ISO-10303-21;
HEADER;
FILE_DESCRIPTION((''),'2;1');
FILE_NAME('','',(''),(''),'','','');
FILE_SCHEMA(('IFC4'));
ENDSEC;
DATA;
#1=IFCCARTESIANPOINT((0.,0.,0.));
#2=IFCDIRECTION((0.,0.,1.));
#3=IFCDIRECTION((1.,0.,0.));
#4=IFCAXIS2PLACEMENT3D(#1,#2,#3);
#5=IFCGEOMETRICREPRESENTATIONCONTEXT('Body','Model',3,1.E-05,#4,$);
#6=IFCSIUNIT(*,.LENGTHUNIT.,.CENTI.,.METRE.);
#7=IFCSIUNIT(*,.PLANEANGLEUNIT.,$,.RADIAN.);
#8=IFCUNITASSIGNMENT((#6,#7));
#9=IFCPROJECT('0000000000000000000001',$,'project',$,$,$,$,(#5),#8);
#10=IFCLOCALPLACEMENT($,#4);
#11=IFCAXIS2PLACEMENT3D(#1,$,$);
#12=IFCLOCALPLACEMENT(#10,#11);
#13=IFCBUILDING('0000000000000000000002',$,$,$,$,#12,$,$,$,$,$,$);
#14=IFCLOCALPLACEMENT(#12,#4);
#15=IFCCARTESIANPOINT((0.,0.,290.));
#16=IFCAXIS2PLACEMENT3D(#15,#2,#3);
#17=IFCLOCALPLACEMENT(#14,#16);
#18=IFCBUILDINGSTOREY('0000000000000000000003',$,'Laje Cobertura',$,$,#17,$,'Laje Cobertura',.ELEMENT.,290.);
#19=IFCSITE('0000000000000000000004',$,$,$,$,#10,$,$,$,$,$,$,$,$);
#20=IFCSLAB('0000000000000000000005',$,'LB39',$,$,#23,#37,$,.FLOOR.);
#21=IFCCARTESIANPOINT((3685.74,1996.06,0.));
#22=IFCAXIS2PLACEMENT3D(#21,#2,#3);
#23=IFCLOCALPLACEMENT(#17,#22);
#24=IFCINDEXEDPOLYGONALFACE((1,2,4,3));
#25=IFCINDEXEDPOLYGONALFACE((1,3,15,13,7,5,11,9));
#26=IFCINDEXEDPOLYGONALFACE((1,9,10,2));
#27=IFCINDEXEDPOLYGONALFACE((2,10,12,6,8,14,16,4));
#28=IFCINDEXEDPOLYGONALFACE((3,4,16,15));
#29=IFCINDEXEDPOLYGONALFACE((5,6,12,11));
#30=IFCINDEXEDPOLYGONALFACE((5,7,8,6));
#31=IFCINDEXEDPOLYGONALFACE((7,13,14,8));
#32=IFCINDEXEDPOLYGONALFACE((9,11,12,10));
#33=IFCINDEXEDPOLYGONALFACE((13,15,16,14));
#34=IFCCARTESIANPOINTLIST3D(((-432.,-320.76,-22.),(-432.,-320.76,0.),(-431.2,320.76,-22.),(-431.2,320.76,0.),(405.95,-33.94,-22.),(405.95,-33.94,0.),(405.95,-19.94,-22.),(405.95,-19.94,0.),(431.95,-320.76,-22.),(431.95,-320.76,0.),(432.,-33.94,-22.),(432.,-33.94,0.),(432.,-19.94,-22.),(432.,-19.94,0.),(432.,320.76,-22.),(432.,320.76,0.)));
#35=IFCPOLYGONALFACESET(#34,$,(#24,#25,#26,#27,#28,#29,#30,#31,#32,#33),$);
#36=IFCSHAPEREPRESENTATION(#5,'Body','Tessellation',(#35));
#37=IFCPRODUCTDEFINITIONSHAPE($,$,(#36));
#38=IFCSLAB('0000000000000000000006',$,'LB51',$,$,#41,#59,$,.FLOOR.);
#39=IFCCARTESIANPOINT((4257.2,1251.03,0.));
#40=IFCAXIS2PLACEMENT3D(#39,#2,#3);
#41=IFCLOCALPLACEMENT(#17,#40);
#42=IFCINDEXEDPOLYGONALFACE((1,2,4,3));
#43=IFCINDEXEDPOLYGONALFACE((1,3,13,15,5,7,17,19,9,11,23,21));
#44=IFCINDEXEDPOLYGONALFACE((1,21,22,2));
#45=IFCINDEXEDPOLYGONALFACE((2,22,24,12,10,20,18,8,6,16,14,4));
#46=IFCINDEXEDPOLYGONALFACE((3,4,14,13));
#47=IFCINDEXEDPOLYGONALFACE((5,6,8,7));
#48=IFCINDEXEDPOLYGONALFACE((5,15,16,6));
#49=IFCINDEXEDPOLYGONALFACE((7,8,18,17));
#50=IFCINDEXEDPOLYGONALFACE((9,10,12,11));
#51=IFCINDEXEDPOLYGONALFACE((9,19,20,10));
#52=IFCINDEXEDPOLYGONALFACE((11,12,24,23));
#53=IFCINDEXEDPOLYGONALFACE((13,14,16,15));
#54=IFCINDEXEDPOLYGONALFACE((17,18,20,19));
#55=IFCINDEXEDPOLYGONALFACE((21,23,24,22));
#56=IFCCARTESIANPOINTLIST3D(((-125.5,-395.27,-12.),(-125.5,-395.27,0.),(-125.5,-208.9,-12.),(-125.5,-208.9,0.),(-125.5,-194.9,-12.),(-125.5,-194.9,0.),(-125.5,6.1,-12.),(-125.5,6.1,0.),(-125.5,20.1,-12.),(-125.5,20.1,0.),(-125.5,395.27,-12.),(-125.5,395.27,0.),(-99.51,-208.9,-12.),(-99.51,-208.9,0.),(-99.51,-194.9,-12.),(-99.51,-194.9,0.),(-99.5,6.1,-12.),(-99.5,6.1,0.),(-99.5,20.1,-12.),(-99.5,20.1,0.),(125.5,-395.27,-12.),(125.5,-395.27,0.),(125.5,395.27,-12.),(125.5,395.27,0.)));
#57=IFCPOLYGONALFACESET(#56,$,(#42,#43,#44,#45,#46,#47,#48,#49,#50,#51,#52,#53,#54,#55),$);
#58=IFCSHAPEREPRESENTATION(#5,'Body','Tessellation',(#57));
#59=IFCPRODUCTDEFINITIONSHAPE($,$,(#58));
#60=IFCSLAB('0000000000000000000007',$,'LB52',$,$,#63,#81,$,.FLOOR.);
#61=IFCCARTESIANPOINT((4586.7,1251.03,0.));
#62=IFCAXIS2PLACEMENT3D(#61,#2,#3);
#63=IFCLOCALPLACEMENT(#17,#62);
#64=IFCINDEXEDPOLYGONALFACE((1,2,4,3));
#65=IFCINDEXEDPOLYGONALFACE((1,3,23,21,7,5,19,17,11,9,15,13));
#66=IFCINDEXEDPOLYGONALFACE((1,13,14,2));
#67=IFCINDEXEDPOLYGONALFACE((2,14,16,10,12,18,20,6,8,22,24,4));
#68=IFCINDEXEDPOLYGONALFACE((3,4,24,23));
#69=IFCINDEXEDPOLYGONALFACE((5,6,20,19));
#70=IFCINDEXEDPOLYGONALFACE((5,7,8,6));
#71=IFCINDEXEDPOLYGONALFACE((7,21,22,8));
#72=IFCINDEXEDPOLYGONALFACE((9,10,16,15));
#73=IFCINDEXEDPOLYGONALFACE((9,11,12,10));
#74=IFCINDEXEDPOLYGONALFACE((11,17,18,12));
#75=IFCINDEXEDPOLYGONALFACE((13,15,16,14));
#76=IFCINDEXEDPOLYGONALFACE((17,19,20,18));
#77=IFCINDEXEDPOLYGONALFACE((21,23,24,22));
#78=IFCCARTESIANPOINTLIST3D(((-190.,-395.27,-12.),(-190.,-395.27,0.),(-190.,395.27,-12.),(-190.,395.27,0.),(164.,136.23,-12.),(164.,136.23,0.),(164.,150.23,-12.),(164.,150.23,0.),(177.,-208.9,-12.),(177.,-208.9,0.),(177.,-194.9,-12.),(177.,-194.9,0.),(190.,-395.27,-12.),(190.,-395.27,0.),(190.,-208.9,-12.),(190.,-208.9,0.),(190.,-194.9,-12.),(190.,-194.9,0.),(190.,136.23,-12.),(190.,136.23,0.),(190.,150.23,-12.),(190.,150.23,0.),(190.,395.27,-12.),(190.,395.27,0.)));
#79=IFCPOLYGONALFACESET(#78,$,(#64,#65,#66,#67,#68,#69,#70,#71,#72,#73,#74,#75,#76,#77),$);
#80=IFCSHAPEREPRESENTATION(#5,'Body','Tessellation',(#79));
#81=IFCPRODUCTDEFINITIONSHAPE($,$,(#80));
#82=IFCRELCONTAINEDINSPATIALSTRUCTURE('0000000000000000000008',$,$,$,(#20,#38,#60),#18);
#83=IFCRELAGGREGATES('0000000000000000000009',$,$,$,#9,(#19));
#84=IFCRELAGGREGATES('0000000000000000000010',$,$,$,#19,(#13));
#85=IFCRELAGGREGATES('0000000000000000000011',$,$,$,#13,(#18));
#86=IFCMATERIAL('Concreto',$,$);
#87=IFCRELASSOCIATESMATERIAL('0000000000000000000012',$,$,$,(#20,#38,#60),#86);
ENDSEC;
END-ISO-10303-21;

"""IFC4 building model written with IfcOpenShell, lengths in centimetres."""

from ifc_helpers import new_model, si_unit, frame, origin, origin_with_axes, place, context, project, spatial, polyline, outline, extrude, material, element, save


model = new_model("IFC4")

# Units and contexts
model_context = context("Model", 3, precision=1e-05, world=origin_with_axes(), identifier="Body")
ifc_project = project(units=[si_unit("LENGTHUNIT", "METRE", prefix="CENTI"), si_unit("PLANEANGLEUNIT", "RADIAN")], contexts=[model_context])

# Site, building, storey
site_placement = place(None, origin_with_axes())
site = spatial("IfcSite", under=ifc_project, at=site_placement)
building_placement = place(site_placement, origin())
building = spatial("IfcBuilding", under=site, at=building_placement)
placement = place(building_placement, origin_with_axes())
storey_placement = place(placement, frame((0.0, 0.0, 290.0), z_axis=(0.0, 0.0, 1.0), x_axis=(1.0, 0.0, 0.0)))
storey = spatial("IfcBuildingStorey", under=building, at=storey_placement, Name="Laje Cobertura", LongName="Laje Cobertura", CompositionType="ELEMENT", Elevation=290.0)

# Shared definitions
ifc_material = material(Name="Concreto")

# Slabs
slab_1_placement = place(storey_placement, frame((3685.74, 1996.06, 0.0), z_axis=(0.0, 0.0, 1.0), x_axis=(1.0, 0.0, 0.0)))
element("IfcSlab", 1, at=slab_1_placement, inside=storey, material=ifc_material, Name="LB39", PredefinedType="FLOOR", context=model_context, shape_type="SolidModel", body=[
    extrude(outline(polyline([(432.0, -33.94), (405.95, -33.95), (405.95, -19.95), (432.0, -19.94), (432.0, 320.75), (-431.2, 320.75), (-432.0, -320.75), (431.95, -320.75), (432.0, -33.94), (432.0, -33.94)])), frame((0.0, 0.0, -22.0), z_axis=(0.0, 0.0, 1.0), x_axis=(1.0, 0.0, 0.0)), (0.0, 0.0, 1.0), 22.0),
])
slab_2_placement = place(storey_placement, frame((4257.2, 1251.03, 0.0), z_axis=(0.0, 0.0, 1.0), x_axis=(1.0, 0.0, 0.0)))
element("IfcSlab", 2, at=slab_2_placement, inside=storey, material=ifc_material, Name="LB51", PredefinedType="FLOOR", context=model_context, shape_type="SolidModel", body=[
    extrude(outline(polyline([(125.5, -395.27), (125.5, 395.27), (-125.5, 395.27), (-125.5, 20.1), (-99.5, 20.1), (-99.5, 6.1), (-125.5, 6.1), (-125.5, -194.9), (-99.51, -194.9), (-99.51, -208.9), (-125.5, -208.9), (-125.5, -395.27), (125.5, -395.27), (125.5, -395.27)])), frame((0.0, 0.0, -12.0), z_axis=(0.0, 0.0, 1.0), x_axis=(1.0, 0.0, 0.0)), (0.0, 0.0, 1.0), 12.0),
])
slab_3_placement = place(storey_placement, frame((4586.7, 1251.03, 0.0), z_axis=(0.0, 0.0, 1.0), x_axis=(1.0, 0.0, 0.0)))
element("IfcSlab", 3, at=slab_3_placement, inside=storey, material=ifc_material, Name="LB52", PredefinedType="FLOOR", context=model_context, shape_type="SolidModel", body=[
    extrude(outline(polyline([(190.0, -395.27), (190.0, -208.9), (177.0, -208.9), (177.0, -194.9), (190.0, -194.9), (190.0, 136.23), (164.0, 136.23), (164.0, 150.23), (190.0, 150.23), (190.0, 395.27), (-190.0, 395.27), (-190.0, -395.27), (190.0, -395.27), (190.0, -395.27)])), frame((0.0, 0.0, -12.0), z_axis=(0.0, 0.0, 1.0), x_axis=(1.0, 0.0, 0.0)), (0.0, 0.0, 1.0), 12.0),
])

save(model, "model.ifc")
